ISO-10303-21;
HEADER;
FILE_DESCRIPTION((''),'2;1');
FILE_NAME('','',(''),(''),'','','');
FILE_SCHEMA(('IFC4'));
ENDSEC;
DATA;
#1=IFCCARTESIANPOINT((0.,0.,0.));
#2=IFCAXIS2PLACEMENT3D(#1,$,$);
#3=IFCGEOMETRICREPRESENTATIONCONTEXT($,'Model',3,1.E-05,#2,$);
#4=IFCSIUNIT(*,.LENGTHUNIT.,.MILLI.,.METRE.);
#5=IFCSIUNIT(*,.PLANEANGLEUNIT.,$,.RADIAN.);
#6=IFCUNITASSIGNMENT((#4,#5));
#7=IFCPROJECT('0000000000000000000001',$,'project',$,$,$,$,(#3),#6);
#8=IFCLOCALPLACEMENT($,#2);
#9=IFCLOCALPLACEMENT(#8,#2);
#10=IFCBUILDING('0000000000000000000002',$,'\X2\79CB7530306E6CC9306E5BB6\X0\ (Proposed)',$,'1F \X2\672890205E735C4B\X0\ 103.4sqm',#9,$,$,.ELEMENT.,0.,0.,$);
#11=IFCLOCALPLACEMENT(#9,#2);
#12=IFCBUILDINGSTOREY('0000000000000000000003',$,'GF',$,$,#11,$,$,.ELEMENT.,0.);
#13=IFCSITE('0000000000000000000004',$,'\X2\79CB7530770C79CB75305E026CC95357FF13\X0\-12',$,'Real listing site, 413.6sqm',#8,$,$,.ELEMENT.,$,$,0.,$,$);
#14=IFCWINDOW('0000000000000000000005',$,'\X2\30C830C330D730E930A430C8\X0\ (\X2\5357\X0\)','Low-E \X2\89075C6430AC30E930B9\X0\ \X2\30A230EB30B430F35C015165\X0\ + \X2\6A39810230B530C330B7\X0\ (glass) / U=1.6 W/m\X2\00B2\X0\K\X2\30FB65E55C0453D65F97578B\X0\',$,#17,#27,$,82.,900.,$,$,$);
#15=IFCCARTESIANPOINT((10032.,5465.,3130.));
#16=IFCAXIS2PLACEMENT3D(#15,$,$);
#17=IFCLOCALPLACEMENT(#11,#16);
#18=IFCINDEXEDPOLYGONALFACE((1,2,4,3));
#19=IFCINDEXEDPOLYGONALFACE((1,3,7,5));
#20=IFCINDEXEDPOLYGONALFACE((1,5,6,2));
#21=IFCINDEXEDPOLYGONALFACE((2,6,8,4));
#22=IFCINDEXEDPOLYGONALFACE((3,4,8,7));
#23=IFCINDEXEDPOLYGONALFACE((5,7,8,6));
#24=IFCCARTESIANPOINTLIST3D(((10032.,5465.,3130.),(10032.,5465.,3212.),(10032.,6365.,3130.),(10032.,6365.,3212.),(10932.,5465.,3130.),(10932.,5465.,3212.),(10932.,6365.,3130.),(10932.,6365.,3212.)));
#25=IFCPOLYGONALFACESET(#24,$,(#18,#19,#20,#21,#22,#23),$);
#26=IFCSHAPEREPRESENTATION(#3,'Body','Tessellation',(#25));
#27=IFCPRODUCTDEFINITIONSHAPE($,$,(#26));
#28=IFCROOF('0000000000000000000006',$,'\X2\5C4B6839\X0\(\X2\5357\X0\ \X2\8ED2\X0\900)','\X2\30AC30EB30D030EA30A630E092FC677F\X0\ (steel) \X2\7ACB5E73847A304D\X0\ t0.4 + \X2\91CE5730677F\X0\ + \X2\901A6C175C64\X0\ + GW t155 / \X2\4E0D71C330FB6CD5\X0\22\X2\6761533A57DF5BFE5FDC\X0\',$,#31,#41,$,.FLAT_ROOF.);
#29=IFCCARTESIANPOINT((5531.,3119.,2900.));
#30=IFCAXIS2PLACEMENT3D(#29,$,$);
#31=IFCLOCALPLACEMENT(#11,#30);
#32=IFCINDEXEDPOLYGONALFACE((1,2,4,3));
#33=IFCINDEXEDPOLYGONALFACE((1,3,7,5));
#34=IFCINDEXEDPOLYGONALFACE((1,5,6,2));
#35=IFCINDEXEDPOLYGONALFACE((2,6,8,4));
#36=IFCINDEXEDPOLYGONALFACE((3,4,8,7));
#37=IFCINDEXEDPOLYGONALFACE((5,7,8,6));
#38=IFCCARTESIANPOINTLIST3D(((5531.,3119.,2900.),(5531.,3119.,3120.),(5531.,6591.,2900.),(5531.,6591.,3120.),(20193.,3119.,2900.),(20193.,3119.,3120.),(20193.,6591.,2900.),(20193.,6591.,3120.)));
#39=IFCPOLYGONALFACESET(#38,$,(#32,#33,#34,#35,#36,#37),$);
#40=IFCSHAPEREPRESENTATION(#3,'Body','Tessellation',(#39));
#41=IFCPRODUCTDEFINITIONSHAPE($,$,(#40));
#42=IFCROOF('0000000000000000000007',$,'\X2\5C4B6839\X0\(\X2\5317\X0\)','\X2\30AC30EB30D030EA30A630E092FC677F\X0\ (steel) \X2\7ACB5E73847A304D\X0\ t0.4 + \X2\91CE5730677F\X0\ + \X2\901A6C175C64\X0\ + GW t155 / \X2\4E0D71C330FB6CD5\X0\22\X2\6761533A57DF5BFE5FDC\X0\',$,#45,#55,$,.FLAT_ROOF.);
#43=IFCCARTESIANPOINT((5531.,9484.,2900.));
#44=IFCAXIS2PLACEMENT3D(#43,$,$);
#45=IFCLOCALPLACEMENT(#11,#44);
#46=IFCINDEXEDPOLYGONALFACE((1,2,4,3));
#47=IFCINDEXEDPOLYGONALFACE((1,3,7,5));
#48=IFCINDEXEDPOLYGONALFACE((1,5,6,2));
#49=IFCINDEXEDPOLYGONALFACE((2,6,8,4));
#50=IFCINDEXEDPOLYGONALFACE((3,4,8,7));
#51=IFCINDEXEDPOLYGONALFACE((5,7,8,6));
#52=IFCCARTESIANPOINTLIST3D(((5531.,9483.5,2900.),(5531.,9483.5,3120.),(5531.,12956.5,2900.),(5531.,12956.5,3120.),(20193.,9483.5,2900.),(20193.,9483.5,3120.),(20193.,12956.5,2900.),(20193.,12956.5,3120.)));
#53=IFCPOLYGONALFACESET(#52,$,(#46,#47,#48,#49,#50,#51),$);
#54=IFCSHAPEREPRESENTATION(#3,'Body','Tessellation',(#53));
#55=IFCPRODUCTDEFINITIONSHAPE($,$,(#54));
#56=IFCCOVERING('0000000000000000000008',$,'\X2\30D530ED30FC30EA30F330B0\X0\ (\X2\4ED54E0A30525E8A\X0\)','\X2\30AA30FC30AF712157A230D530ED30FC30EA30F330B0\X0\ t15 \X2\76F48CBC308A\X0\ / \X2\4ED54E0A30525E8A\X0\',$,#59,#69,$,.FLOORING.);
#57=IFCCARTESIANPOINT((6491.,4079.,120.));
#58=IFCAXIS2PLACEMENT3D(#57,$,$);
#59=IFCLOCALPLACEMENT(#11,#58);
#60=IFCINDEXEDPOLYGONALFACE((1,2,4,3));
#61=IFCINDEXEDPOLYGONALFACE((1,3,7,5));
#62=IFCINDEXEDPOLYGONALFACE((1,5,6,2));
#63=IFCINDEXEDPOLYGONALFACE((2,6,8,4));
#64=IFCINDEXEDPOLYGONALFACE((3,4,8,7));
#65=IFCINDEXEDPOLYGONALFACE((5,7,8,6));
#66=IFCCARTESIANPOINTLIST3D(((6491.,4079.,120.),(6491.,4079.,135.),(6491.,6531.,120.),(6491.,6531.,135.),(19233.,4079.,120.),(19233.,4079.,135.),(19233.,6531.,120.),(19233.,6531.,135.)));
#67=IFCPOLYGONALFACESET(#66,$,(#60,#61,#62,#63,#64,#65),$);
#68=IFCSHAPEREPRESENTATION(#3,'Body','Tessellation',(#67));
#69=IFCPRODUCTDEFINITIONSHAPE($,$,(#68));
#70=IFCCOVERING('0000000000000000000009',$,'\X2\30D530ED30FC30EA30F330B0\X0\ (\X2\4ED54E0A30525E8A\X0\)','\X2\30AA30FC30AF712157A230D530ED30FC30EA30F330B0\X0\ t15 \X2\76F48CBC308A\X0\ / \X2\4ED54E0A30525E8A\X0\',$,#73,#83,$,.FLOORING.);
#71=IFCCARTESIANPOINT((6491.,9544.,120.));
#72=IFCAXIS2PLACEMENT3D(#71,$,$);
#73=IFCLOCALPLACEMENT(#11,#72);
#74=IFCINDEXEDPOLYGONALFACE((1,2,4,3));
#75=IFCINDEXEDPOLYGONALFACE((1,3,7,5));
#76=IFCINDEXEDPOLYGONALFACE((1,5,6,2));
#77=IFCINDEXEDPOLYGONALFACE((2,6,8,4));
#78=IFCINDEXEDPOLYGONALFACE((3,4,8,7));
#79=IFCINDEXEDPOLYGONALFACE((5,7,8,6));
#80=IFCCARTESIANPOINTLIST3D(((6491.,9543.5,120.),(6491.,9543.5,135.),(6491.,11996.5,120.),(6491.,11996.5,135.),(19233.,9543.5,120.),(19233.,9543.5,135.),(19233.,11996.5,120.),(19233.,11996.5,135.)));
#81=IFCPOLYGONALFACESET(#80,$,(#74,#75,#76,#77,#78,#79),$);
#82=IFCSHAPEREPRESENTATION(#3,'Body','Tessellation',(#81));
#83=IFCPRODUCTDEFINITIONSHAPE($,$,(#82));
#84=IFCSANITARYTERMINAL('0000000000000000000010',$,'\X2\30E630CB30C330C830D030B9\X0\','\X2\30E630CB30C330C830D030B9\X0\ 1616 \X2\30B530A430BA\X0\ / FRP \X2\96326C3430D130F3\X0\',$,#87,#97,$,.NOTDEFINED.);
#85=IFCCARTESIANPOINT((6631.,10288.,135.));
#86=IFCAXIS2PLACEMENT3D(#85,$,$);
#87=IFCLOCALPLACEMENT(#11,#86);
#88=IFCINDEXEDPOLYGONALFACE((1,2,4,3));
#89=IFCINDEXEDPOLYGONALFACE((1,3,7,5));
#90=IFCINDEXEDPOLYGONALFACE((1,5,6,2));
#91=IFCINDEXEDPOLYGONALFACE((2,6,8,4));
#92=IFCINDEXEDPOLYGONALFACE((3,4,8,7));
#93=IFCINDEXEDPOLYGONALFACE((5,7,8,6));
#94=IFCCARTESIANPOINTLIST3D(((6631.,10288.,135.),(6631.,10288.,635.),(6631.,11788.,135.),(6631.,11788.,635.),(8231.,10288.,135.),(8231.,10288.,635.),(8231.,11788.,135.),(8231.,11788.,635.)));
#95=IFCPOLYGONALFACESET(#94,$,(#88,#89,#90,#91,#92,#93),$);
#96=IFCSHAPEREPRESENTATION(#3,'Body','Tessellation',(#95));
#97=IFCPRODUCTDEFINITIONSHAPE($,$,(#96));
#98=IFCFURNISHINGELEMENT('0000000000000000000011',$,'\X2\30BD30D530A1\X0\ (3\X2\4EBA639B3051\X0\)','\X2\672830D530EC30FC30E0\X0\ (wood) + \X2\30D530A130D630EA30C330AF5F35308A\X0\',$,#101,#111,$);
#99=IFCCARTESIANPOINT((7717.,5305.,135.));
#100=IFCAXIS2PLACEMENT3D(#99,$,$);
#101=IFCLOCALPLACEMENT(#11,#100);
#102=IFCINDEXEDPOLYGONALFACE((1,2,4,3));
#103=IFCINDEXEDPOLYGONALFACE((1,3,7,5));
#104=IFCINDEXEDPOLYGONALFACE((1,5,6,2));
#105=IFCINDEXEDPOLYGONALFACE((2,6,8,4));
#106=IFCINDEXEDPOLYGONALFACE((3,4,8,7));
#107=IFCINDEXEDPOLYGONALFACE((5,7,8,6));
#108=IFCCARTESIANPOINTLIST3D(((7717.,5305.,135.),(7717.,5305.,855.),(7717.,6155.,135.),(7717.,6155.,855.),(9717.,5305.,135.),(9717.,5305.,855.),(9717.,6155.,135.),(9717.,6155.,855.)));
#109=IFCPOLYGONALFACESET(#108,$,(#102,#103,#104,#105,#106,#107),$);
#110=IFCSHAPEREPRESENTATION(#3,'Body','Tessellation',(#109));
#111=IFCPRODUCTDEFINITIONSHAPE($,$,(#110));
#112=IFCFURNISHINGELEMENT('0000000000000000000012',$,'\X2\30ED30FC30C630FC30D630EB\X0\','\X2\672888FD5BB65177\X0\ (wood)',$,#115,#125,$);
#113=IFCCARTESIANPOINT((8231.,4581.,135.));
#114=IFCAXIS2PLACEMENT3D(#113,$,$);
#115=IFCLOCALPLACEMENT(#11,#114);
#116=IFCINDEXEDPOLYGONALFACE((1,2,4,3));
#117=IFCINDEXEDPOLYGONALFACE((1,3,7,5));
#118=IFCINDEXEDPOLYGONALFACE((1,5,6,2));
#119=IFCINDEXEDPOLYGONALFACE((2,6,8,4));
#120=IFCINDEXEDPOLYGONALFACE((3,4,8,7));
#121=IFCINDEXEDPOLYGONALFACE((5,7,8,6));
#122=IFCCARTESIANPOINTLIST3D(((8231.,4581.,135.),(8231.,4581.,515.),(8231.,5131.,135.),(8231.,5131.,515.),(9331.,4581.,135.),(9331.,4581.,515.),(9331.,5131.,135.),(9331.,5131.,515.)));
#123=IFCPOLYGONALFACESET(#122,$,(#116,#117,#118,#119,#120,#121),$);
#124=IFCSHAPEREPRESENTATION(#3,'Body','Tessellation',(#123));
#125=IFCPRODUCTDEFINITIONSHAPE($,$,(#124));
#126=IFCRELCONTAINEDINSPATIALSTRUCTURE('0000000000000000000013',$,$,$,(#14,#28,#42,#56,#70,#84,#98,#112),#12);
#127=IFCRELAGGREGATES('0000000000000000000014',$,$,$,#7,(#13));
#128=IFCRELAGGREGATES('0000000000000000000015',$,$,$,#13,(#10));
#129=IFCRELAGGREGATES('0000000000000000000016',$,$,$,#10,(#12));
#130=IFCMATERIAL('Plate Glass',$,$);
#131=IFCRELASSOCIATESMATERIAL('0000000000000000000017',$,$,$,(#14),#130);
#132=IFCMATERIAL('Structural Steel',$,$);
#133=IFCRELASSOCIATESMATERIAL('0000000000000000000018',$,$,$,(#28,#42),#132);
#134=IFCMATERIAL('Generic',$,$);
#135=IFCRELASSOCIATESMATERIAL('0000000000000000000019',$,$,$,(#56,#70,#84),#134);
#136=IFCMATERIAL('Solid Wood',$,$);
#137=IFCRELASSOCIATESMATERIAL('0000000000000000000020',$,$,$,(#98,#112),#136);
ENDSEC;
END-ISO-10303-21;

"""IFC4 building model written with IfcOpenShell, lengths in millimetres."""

from ifc_helpers import new_model, si_unit, frame, frame_2d, origin, place, context, project, spatial, rectangle, extrude, material, element, save


model = new_model("IFC4")

# Units and contexts
model_context = context("Model", 3, precision=1e-05, world=origin())
ifc_project = project(units=[si_unit("LENGTHUNIT", "METRE", prefix="MILLI"), si_unit("PLANEANGLEUNIT", "RADIAN")], contexts=[model_context])

# Site, building, storey
site_placement = place(None, origin())
site = spatial("IfcSite", under=ifc_project, at=site_placement, Name="秋田県秋田市泉南３-12", ObjectType="Real listing site, 413.6sqm", CompositionType="ELEMENT", RefElevation=0.0)
building_placement = place(site_placement, origin())
building = spatial("IfcBuilding", under=site, at=building_placement, Name="秋田の泉の家 (Proposed)", ObjectType="1F 木造平屋 103.4sqm", CompositionType="ELEMENT", ElevationOfRefHeight=0.0, ElevationOfTerrain=0.0)
storey_placement = place(building_placement, origin())
storey = spatial("IfcBuildingStorey", under=building, at=storey_placement, Name="GF", CompositionType="ELEMENT", Elevation=0.0)

# Shared definitions
ifc_material_1 = material(Name="Solid Wood")

# Shared definitions
ifc_material_2 = material(Name="Plate Glass")

# Window
window_1_placement = place(storey_placement, frame((10032.0, 5465.0, 3130.0)))
element("IfcWindow", 1, at=window_1_placement, inside=storey, material=ifc_material_2, Name="トップライト (南)", Description="Low-E 複層ガラス アルゴン封入 + 樹脂サッシ (glass) / U=1.6 W/m²K・日射取得型", OverallHeight=82.0, OverallWidth=900.0, context=model_context, shape_type="SweptSolid", body=[
    extrude(rectangle(XDim=900.0, YDim=900.0, at=frame_2d((450.0, 450.0))), frame((10032.0, 5465.0, 3130.0)), (0.0, 0.0, 1.0), 82.0),
])

# Roofs
ifc_material_3 = material(Name="Structural Steel")
roof_1_placement = place(storey_placement, frame((5531.0, 3119.0, 2900.0)))
element("IfcRoof", 2, at=roof_1_placement, inside=storey, material=ifc_material_3, Name="屋根(南 軒900)", Description="ガルバリウム鋼板 (steel) 立平葺き t0.4 + 野地板 + 通気層 + GW t155 / 不燃・法22条区域対応", PredefinedType="FLAT_ROOF", context=model_context, shape_type="SweptSolid", body=[
    extrude(rectangle(XDim=14662.0, YDim=3472.0, at=frame_2d((7331.0, 1736.0))), frame((5531.0, 3119.0, 2900.0)), (0.0, 0.0, 1.0), 220.0),
])
roof_2_placement = place(storey_placement, frame((5531.0, 9484.0, 2900.0)))
element("IfcRoof", 3, at=roof_2_placement, inside=storey, material=ifc_material_3, Name="屋根(北)", Description="ガルバリウム鋼板 (steel) 立平葺き t0.4 + 野地板 + 通気層 + GW t155 / 不燃・法22条区域対応", PredefinedType="FLAT_ROOF", context=model_context, shape_type="SweptSolid", body=[
    extrude(rectangle(XDim=14662.0, YDim=3473.0, at=frame_2d((7331.0, 1736.0))), frame((5531.0, 9484.0, 2900.0)), (0.0, 0.0, 1.0), 220.0),
])

# Coverings
ifc_material_4 = material(Name="Generic")
covering_1_placement = place(storey_placement, frame((6491.0, 4079.0, 120.0)))
element("IfcCovering", 4, at=covering_1_placement, inside=storey, material=ifc_material_4, Name="フローリング (仕上げ床)", Description="オーク無垢フローリング t15 直貼り / 仕上げ床", PredefinedType="FLOORING", context=model_context, shape_type="SweptSolid", body=[
    extrude(rectangle(XDim=12742.0, YDim=2452.0, at=frame_2d((6371.0, 1226.0))), frame((6491.0, 4079.0, 120.0)), (0.0, 0.0, 1.0), 15.0),
])
covering_2_placement = place(storey_placement, frame((6491.0, 9544.0, 120.0)))
element("IfcCovering", 5, at=covering_2_placement, inside=storey, material=ifc_material_4, Name="フローリング (仕上げ床)", Description="オーク無垢フローリング t15 直貼り / 仕上げ床", PredefinedType="FLOORING", context=model_context, shape_type="SweptSolid", body=[
    extrude(rectangle(XDim=12742.0, YDim=2453.0, at=frame_2d((6371.0, 1226.0))), frame((6491.0, 9544.0, 120.0)), (0.0, 0.0, 1.0), 15.0),
])

# Sanitary terminal
sanitary_terminal_placement = place(storey_placement, frame((6631.0, 10288.0, 135.0)))
element("IfcSanitaryTerminal", 6, at=sanitary_terminal_placement, inside=storey, material=ifc_material_4, Name="ユニットバス", Description="ユニットバス 1616 サイズ / FRP 防水パン", PredefinedType="NOTDEFINED", context=model_context, shape_type="SweptSolid", body=[
    extrude(rectangle(XDim=1600.0, YDim=1500.0, at=frame_2d((800.0, 750.0))), frame((6631.0, 10288.0, 135.0)), (0.0, 0.0, 1.0), 500.0),
])

# Furnishing elements
furnishing_1_placement = place(storey_placement, frame((7717.0, 5305.0, 135.0)))
element("IfcFurnishingElement", 7, at=furnishing_1_placement, inside=storey, material=ifc_material_1, Name="ソファ (3人掛け)", Description="木フレーム (wood) + ファブリック張り", context=model_context, shape_type="SweptSolid", body=[
    extrude(rectangle(XDim=2000.0, YDim=850.0, at=frame_2d((1000.0, 425.0))), frame((7717.0, 5305.0, 135.0)), (0.0, 0.0, 1.0), 720.0),
])
furnishing_2_placement = place(storey_placement, frame((8231.0, 4581.0, 135.0)))
element("IfcFurnishingElement", 8, at=furnishing_2_placement, inside=storey, material=ifc_material_1, Name="ローテーブル", Description="木製家具 (wood)", context=model_context, shape_type="SweptSolid", body=[
    extrude(rectangle(XDim=1100.0, YDim=550.0, at=frame_2d((550.0, 275.0))), frame((8231.0, 4581.0, 135.0)), (0.0, 0.0, 1.0), 380.0),
])

save(model, "model.ifc")
